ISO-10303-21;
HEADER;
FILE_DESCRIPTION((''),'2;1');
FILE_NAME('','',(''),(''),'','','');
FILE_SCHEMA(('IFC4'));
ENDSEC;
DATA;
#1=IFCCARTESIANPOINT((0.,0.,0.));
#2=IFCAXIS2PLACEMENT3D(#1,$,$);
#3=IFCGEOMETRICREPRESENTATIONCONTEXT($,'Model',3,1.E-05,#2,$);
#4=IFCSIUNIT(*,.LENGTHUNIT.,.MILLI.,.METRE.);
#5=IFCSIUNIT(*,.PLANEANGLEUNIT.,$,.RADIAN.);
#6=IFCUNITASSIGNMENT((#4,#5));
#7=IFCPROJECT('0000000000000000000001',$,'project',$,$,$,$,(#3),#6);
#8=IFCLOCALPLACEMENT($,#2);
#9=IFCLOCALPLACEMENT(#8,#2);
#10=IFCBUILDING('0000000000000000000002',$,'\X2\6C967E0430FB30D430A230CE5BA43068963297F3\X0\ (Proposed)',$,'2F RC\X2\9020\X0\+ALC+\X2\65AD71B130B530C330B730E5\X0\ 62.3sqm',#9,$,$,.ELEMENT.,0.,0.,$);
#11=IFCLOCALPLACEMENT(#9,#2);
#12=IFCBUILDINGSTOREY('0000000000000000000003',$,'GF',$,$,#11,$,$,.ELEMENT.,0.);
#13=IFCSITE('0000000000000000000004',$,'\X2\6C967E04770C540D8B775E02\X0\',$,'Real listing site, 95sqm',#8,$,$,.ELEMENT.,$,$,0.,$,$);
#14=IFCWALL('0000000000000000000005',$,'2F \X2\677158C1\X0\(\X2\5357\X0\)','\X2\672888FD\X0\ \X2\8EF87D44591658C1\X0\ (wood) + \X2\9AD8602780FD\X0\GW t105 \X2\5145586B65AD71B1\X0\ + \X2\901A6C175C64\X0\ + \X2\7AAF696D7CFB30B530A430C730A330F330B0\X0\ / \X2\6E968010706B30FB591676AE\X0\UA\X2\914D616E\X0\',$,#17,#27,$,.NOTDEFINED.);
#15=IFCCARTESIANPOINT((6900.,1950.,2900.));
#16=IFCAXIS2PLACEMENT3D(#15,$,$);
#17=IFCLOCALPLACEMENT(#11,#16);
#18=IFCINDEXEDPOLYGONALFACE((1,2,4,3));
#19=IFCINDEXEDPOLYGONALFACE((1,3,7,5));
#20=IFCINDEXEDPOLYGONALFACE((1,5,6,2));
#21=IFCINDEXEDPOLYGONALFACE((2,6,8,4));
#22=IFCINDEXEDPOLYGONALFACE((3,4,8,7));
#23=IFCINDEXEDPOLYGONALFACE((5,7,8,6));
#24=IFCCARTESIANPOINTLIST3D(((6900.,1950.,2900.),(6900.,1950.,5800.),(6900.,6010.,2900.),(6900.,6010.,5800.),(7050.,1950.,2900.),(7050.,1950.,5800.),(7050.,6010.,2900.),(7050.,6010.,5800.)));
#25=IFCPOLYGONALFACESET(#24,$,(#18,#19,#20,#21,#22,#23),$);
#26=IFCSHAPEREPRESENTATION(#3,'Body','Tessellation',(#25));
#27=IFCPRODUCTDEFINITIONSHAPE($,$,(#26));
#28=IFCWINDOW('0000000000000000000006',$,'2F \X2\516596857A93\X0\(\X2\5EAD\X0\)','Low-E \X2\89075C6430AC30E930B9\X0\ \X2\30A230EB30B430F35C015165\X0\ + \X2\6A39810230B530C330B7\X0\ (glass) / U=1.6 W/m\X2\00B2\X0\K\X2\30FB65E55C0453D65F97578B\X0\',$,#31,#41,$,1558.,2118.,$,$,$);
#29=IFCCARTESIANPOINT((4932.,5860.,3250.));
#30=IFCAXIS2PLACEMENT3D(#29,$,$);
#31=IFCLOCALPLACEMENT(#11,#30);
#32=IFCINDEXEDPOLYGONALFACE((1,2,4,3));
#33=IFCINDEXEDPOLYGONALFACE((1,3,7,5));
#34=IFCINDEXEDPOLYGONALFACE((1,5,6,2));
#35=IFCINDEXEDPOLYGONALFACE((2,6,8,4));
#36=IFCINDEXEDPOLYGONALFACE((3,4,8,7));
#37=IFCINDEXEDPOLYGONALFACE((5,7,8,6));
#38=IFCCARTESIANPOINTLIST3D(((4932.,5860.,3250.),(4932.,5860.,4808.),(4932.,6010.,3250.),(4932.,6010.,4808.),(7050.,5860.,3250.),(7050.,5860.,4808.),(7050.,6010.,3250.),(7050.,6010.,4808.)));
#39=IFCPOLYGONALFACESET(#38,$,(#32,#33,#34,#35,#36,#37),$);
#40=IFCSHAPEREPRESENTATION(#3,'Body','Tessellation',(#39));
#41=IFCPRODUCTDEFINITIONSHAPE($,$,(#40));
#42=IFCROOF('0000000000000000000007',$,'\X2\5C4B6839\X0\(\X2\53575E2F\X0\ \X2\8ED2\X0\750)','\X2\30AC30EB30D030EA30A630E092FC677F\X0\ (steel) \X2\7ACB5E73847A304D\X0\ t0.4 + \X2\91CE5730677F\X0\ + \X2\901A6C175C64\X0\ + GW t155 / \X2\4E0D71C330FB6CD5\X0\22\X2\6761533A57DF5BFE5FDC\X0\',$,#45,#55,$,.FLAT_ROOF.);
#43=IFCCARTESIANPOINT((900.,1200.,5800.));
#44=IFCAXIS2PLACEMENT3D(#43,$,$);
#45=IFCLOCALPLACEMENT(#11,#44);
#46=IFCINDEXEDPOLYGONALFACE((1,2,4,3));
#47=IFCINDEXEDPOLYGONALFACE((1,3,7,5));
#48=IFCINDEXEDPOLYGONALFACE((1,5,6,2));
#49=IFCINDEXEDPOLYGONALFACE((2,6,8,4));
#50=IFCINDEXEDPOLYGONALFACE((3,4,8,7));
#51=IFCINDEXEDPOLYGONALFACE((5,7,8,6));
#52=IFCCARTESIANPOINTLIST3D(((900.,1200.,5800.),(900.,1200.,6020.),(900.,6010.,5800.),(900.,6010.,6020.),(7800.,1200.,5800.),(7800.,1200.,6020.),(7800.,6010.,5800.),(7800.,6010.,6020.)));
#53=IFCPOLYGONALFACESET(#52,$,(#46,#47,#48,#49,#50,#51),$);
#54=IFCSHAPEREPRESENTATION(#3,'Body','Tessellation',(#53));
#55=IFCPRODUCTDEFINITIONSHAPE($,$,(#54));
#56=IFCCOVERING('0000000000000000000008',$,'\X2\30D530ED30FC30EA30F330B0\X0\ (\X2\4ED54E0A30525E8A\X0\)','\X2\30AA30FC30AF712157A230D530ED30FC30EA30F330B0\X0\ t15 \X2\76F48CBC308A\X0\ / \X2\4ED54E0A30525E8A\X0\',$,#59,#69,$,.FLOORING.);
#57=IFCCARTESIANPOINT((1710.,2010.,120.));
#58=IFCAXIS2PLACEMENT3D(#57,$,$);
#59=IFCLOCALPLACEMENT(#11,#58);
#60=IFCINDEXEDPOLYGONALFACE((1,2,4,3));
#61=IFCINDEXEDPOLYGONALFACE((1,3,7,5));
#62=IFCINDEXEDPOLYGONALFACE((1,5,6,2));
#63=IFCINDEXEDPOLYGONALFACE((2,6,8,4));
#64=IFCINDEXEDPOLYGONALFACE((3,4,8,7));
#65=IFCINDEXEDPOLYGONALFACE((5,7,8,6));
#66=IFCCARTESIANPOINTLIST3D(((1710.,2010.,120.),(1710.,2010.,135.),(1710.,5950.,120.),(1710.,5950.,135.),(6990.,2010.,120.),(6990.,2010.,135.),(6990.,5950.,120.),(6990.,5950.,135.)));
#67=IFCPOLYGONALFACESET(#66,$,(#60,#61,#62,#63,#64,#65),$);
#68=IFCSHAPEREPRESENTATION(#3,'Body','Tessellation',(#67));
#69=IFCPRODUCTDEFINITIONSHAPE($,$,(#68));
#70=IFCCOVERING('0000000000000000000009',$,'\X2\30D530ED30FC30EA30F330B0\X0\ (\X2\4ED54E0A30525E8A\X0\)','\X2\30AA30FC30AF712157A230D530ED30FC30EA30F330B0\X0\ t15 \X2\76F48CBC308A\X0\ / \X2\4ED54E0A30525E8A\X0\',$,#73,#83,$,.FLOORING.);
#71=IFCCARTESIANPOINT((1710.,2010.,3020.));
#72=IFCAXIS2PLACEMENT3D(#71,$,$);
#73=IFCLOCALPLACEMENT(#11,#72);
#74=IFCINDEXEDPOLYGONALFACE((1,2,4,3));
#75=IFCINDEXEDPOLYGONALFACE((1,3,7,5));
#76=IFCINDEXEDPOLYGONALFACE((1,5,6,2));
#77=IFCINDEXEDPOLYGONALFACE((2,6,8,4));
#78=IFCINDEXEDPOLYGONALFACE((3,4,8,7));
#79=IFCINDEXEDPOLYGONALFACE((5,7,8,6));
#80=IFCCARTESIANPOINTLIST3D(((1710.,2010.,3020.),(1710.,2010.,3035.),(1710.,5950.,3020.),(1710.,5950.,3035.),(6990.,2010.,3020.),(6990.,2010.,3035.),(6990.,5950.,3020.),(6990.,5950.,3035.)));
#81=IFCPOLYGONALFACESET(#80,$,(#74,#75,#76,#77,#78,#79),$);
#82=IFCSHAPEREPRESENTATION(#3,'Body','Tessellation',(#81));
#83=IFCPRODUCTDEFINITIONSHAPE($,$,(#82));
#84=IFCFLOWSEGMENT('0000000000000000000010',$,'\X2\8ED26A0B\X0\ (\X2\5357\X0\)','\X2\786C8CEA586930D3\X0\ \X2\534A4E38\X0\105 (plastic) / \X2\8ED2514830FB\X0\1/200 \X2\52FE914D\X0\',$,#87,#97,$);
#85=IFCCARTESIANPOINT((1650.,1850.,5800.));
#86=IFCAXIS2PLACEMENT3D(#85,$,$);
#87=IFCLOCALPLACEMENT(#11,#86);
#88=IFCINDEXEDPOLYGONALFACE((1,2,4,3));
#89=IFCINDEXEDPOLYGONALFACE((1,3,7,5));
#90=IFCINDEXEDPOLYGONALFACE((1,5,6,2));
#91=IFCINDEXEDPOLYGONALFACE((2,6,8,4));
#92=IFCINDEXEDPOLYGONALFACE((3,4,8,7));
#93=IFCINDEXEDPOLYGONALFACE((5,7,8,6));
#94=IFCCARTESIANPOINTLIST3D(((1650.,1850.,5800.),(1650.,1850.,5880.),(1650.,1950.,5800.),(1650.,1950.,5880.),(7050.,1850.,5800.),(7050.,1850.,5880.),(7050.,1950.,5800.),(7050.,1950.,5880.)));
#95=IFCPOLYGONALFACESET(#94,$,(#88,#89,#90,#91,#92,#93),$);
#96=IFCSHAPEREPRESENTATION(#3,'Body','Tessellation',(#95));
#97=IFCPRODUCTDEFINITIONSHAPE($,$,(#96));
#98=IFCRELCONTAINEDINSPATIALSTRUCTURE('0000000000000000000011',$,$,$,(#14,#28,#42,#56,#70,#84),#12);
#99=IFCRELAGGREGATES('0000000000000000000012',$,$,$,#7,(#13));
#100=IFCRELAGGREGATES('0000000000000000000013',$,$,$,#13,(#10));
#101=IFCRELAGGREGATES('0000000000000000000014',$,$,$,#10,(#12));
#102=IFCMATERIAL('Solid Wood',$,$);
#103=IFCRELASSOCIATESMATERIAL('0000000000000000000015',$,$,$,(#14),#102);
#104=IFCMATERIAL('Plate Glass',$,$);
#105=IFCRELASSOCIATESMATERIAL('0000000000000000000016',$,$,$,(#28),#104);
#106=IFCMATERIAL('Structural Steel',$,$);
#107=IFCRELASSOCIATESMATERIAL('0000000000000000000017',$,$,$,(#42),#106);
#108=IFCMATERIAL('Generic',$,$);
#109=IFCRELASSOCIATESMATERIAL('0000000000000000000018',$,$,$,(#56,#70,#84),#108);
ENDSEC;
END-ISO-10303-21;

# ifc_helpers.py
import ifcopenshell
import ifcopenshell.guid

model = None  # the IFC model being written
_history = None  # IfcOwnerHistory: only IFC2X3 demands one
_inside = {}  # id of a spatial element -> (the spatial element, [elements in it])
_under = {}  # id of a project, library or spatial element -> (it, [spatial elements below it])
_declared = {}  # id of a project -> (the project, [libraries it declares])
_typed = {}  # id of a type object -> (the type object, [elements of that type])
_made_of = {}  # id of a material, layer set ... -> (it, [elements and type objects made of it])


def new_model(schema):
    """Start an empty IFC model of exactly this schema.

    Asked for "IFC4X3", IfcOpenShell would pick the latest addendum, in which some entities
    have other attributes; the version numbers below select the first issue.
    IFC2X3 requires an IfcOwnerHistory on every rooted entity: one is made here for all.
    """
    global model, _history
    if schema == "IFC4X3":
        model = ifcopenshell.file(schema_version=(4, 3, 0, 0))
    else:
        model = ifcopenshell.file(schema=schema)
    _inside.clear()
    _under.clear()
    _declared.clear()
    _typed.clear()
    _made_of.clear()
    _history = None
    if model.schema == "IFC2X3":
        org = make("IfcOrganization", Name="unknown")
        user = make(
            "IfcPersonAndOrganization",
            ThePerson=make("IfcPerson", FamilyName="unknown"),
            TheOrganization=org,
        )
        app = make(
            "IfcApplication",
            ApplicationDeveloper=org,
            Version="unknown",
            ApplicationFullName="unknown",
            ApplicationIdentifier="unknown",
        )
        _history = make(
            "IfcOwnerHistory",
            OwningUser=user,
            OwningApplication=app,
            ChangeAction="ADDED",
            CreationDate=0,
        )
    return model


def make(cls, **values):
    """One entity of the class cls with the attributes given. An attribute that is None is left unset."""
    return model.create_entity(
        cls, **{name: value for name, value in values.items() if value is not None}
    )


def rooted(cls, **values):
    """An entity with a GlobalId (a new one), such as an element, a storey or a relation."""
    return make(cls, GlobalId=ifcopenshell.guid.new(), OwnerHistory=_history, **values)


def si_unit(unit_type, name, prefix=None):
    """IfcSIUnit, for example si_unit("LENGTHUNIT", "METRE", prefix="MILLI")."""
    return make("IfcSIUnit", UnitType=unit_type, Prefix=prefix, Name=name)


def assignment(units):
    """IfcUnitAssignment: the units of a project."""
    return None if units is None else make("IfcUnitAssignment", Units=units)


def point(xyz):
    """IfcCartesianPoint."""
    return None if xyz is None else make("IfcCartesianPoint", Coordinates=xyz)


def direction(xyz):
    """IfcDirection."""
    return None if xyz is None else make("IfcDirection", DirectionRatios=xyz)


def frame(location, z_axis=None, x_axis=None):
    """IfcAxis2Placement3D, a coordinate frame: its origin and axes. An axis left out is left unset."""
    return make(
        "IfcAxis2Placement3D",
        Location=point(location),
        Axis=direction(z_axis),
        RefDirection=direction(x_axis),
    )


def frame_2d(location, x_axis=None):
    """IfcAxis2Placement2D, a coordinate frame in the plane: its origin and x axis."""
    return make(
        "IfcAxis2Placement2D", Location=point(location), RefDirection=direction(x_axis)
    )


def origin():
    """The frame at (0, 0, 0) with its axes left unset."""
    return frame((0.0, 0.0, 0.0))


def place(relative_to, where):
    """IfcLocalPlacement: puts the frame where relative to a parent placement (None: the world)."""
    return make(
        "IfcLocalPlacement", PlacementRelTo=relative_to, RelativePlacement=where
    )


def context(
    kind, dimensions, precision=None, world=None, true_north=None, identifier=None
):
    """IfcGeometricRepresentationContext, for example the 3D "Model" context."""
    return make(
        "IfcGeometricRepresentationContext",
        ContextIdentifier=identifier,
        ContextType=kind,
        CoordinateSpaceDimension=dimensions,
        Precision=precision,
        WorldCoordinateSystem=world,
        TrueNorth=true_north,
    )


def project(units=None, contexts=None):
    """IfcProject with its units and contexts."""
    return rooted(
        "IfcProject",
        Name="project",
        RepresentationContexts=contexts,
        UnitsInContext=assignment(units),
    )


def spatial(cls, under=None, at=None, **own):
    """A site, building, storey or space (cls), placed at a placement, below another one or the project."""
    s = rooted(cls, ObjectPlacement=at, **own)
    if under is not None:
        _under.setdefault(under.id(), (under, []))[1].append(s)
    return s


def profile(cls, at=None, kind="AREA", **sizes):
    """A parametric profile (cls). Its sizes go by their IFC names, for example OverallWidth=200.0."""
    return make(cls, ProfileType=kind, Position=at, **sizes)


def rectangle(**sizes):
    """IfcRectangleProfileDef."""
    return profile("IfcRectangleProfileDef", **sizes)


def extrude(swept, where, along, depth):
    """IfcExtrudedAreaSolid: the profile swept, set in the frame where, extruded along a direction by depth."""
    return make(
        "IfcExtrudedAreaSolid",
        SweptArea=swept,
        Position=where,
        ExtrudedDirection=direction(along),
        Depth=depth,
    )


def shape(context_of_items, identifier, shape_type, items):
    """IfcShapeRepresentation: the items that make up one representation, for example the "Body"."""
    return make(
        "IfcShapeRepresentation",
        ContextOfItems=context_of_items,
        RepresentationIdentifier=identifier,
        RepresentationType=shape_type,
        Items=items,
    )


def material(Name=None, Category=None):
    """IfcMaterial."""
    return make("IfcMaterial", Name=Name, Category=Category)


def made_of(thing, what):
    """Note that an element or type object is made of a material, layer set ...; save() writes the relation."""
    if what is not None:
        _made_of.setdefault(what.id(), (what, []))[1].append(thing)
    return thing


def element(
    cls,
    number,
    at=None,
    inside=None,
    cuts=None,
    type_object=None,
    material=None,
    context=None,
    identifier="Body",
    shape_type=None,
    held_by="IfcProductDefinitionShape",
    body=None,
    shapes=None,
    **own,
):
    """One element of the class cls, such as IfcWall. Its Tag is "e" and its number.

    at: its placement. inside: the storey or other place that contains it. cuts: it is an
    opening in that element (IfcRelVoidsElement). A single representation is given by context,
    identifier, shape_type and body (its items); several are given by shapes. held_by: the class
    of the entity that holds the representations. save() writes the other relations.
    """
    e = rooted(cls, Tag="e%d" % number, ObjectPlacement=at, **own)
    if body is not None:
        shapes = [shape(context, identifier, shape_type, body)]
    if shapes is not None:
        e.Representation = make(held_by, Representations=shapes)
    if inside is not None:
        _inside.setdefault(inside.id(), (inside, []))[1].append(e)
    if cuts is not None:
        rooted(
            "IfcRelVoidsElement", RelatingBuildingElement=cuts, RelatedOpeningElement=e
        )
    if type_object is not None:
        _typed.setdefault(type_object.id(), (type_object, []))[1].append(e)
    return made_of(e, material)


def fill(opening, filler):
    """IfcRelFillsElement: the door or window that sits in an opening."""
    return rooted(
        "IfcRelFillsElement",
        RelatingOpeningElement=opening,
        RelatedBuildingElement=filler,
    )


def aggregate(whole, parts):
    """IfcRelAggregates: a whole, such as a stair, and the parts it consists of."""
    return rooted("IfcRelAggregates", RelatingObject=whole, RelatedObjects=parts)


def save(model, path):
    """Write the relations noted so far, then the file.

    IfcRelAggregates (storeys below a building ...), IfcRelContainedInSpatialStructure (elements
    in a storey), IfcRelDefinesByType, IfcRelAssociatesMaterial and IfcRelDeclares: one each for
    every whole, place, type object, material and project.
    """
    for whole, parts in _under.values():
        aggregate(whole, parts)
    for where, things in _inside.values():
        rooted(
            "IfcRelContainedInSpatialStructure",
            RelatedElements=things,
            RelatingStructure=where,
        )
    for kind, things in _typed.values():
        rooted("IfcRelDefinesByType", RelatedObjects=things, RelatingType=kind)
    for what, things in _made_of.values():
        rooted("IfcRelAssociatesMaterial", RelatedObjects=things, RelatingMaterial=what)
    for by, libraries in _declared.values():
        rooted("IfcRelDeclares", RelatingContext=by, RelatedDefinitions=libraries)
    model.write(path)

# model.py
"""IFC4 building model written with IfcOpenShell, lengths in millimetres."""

from ifc_helpers import new_model, si_unit, frame, frame_2d, origin, place, context, project, spatial, rectangle, extrude, material, element, fill, save


model = new_model("IFC4")

# Units and contexts
model_context = context("Model", 3, precision=1e-05, world=origin())
ifc_project = project(units=[si_unit("LENGTHUNIT", "METRE", prefix="MILLI"), si_unit("PLANEANGLEUNIT", "RADIAN")], contexts=[model_context])

# Site, building, storey
site_placement = place(None, origin())
site = spatial("IfcSite", under=ifc_project, at=site_placement, Name="沖縄県名護市", ObjectType="Real listing site, 95sqm", CompositionType="ELEMENT", RefElevation=0.0)
building_placement = place(site_placement, origin())
building = spatial("IfcBuilding", under=site, at=building_placement, Name="沖縄・ピアノ室と防音 (Proposed)", ObjectType="2F RC造+ALC+断熱サッシュ 62.3sqm", CompositionType="ELEMENT", ElevationOfRefHeight=0.0, ElevationOfTerrain=0.0)
storey_placement = place(building_placement, origin())
storey = spatial("IfcBuildingStorey", under=building, at=storey_placement, Name="GF", CompositionType="ELEMENT", Elevation=0.0)

# Shared definitions
ifc_material_1 = material(Name="Solid Wood")

# Wall, opening, window
ifc_material_2 = material(Name="Plate Glass")
wall_1_placement = place(storey_placement, frame((6900.0, 1950.0, 2900.0)))
wall_1 = element("IfcWall", 1, at=wall_1_placement, inside=storey, material=ifc_material_1, Name="2F 東壁(南)", Description="木製 軸組外壁 (wood) + 高性能GW t105 充填断熱 + 通気層 + 窯業系サイディング / 準耐火・外皮UA配慮", PredefinedType="NOTDEFINED", context=model_context, shape_type="SweptSolid", body=[
    extrude(rectangle(XDim=150.0, YDim=4060.0, at=frame_2d((75.0, 2030.0))), frame((6900.0, 1950.0, 2900.0)), (0.0, 0.0, 1.0), 2900.0),
])
opening_1_placement = place(storey_placement, frame((4932.0, 5860.0, 3250.0)))
opening_1 = element("IfcOpeningElement", 2, at=opening_1_placement, cuts=wall_1, PredefinedType="NOTDEFINED", context=model_context, shape_type="SweptSolid", body=[
    extrude(rectangle(XDim=2118.0, YDim=150.0, at=frame_2d((1059.0, 75.0))), frame((4932.0, 5860.0, 3250.0)), (0.0, 0.0, 1.0), 1558.0),
])
window_1_placement = place(storey_placement, frame((4932.0, 5860.0, 3250.0)))
window_1 = element("IfcWindow", 3, at=window_1_placement, inside=storey, material=ifc_material_2, Name="2F 入隅窓(庭)", Description="Low-E 複層ガラス アルゴン封入 + 樹脂サッシ (glass) / U=1.6 W/m²K・日射取得型", OverallHeight=1558.0, OverallWidth=2118.0, context=model_context, shape_type="SweptSolid", body=[
    extrude(rectangle(XDim=2118.0, YDim=150.0, at=frame_2d((1059.0, 75.0))), frame((4932.0, 5860.0, 3250.0)), (0.0, 0.0, 1.0), 1558.0),
])
fill(opening_1, window_1)

# Roof
ifc_material_3 = material(Name="Structural Steel")
for number, where, name in (
    (4, (900.0, 1200.0, 5800.0), "屋根(南帯 軒750)"),
):
    element("IfcRoof", number, at=place(storey_placement, frame(where)), inside=storey, material=ifc_material_3, Name=name, Description="ガルバリウム鋼板 (steel) 立平葺き t0.4 + 野地板 + 通気層 + GW t155 / 不燃・法22条区域対応", PredefinedType="FLAT_ROOF", context=model_context, shape_type="SweptSolid", body=[
        extrude(rectangle(XDim=6900.0, YDim=4810.0, at=frame_2d((3450.0, 2405.0))), frame((900.0, 1200.0, 5800.0)), (0.0, 0.0, 1.0), 220.0),
    ])

# Coverings
ifc_material_4 = material(Name="Generic")
covering_1_placement = place(storey_placement, frame((1710.0, 2010.0, 120.0)))
element("IfcCovering", 5, at=covering_1_placement, inside=storey, material=ifc_material_4, Name="フローリング (仕上げ床)", Description="オーク無垢フローリング t15 直貼り / 仕上げ床", PredefinedType="FLOORING", context=model_context, shape_type="SweptSolid", body=[
    extrude(rectangle(XDim=5280.0, YDim=3940.0, at=frame_2d((2640.0, 1970.0))), frame((1710.0, 2010.0, 120.0)), (0.0, 0.0, 1.0), 15.0),
])
covering_2_placement = place(storey_placement, frame((1710.0, 2010.0, 3020.0)))
element("IfcCovering", 6, at=covering_2_placement, inside=storey, material=ifc_material_4, Name="フローリング (仕上げ床)", Description="オーク無垢フローリング t15 直貼り / 仕上げ床", PredefinedType="FLOORING", context=model_context, shape_type="SweptSolid", body=[
    extrude(rectangle(XDim=5280.0, YDim=3940.0, at=frame_2d((2640.0, 1970.0))), frame((1710.0, 2010.0, 3020.0)), (0.0, 0.0, 1.0), 15.0),
])

# Flow segment
flow_segment_placement = place(storey_placement, frame((1650.0, 1850.0, 5800.0)))
element("IfcFlowSegment", 7, at=flow_segment_placement, inside=storey, material=ifc_material_4, Name="軒樋 (南)", Description="硬質塩ビ 半丸105 (plastic) / 軒先・1/200 勾配", context=model_context, shape_type="SweptSolid", body=[
    extrude(rectangle(XDim=5400.0, YDim=100.0, at=frame_2d((2700.0, 50.0))), frame((1650.0, 1850.0, 5800.0)), (0.0, 0.0, 1.0), 80.0),
])

save(model, "model.ifc")
